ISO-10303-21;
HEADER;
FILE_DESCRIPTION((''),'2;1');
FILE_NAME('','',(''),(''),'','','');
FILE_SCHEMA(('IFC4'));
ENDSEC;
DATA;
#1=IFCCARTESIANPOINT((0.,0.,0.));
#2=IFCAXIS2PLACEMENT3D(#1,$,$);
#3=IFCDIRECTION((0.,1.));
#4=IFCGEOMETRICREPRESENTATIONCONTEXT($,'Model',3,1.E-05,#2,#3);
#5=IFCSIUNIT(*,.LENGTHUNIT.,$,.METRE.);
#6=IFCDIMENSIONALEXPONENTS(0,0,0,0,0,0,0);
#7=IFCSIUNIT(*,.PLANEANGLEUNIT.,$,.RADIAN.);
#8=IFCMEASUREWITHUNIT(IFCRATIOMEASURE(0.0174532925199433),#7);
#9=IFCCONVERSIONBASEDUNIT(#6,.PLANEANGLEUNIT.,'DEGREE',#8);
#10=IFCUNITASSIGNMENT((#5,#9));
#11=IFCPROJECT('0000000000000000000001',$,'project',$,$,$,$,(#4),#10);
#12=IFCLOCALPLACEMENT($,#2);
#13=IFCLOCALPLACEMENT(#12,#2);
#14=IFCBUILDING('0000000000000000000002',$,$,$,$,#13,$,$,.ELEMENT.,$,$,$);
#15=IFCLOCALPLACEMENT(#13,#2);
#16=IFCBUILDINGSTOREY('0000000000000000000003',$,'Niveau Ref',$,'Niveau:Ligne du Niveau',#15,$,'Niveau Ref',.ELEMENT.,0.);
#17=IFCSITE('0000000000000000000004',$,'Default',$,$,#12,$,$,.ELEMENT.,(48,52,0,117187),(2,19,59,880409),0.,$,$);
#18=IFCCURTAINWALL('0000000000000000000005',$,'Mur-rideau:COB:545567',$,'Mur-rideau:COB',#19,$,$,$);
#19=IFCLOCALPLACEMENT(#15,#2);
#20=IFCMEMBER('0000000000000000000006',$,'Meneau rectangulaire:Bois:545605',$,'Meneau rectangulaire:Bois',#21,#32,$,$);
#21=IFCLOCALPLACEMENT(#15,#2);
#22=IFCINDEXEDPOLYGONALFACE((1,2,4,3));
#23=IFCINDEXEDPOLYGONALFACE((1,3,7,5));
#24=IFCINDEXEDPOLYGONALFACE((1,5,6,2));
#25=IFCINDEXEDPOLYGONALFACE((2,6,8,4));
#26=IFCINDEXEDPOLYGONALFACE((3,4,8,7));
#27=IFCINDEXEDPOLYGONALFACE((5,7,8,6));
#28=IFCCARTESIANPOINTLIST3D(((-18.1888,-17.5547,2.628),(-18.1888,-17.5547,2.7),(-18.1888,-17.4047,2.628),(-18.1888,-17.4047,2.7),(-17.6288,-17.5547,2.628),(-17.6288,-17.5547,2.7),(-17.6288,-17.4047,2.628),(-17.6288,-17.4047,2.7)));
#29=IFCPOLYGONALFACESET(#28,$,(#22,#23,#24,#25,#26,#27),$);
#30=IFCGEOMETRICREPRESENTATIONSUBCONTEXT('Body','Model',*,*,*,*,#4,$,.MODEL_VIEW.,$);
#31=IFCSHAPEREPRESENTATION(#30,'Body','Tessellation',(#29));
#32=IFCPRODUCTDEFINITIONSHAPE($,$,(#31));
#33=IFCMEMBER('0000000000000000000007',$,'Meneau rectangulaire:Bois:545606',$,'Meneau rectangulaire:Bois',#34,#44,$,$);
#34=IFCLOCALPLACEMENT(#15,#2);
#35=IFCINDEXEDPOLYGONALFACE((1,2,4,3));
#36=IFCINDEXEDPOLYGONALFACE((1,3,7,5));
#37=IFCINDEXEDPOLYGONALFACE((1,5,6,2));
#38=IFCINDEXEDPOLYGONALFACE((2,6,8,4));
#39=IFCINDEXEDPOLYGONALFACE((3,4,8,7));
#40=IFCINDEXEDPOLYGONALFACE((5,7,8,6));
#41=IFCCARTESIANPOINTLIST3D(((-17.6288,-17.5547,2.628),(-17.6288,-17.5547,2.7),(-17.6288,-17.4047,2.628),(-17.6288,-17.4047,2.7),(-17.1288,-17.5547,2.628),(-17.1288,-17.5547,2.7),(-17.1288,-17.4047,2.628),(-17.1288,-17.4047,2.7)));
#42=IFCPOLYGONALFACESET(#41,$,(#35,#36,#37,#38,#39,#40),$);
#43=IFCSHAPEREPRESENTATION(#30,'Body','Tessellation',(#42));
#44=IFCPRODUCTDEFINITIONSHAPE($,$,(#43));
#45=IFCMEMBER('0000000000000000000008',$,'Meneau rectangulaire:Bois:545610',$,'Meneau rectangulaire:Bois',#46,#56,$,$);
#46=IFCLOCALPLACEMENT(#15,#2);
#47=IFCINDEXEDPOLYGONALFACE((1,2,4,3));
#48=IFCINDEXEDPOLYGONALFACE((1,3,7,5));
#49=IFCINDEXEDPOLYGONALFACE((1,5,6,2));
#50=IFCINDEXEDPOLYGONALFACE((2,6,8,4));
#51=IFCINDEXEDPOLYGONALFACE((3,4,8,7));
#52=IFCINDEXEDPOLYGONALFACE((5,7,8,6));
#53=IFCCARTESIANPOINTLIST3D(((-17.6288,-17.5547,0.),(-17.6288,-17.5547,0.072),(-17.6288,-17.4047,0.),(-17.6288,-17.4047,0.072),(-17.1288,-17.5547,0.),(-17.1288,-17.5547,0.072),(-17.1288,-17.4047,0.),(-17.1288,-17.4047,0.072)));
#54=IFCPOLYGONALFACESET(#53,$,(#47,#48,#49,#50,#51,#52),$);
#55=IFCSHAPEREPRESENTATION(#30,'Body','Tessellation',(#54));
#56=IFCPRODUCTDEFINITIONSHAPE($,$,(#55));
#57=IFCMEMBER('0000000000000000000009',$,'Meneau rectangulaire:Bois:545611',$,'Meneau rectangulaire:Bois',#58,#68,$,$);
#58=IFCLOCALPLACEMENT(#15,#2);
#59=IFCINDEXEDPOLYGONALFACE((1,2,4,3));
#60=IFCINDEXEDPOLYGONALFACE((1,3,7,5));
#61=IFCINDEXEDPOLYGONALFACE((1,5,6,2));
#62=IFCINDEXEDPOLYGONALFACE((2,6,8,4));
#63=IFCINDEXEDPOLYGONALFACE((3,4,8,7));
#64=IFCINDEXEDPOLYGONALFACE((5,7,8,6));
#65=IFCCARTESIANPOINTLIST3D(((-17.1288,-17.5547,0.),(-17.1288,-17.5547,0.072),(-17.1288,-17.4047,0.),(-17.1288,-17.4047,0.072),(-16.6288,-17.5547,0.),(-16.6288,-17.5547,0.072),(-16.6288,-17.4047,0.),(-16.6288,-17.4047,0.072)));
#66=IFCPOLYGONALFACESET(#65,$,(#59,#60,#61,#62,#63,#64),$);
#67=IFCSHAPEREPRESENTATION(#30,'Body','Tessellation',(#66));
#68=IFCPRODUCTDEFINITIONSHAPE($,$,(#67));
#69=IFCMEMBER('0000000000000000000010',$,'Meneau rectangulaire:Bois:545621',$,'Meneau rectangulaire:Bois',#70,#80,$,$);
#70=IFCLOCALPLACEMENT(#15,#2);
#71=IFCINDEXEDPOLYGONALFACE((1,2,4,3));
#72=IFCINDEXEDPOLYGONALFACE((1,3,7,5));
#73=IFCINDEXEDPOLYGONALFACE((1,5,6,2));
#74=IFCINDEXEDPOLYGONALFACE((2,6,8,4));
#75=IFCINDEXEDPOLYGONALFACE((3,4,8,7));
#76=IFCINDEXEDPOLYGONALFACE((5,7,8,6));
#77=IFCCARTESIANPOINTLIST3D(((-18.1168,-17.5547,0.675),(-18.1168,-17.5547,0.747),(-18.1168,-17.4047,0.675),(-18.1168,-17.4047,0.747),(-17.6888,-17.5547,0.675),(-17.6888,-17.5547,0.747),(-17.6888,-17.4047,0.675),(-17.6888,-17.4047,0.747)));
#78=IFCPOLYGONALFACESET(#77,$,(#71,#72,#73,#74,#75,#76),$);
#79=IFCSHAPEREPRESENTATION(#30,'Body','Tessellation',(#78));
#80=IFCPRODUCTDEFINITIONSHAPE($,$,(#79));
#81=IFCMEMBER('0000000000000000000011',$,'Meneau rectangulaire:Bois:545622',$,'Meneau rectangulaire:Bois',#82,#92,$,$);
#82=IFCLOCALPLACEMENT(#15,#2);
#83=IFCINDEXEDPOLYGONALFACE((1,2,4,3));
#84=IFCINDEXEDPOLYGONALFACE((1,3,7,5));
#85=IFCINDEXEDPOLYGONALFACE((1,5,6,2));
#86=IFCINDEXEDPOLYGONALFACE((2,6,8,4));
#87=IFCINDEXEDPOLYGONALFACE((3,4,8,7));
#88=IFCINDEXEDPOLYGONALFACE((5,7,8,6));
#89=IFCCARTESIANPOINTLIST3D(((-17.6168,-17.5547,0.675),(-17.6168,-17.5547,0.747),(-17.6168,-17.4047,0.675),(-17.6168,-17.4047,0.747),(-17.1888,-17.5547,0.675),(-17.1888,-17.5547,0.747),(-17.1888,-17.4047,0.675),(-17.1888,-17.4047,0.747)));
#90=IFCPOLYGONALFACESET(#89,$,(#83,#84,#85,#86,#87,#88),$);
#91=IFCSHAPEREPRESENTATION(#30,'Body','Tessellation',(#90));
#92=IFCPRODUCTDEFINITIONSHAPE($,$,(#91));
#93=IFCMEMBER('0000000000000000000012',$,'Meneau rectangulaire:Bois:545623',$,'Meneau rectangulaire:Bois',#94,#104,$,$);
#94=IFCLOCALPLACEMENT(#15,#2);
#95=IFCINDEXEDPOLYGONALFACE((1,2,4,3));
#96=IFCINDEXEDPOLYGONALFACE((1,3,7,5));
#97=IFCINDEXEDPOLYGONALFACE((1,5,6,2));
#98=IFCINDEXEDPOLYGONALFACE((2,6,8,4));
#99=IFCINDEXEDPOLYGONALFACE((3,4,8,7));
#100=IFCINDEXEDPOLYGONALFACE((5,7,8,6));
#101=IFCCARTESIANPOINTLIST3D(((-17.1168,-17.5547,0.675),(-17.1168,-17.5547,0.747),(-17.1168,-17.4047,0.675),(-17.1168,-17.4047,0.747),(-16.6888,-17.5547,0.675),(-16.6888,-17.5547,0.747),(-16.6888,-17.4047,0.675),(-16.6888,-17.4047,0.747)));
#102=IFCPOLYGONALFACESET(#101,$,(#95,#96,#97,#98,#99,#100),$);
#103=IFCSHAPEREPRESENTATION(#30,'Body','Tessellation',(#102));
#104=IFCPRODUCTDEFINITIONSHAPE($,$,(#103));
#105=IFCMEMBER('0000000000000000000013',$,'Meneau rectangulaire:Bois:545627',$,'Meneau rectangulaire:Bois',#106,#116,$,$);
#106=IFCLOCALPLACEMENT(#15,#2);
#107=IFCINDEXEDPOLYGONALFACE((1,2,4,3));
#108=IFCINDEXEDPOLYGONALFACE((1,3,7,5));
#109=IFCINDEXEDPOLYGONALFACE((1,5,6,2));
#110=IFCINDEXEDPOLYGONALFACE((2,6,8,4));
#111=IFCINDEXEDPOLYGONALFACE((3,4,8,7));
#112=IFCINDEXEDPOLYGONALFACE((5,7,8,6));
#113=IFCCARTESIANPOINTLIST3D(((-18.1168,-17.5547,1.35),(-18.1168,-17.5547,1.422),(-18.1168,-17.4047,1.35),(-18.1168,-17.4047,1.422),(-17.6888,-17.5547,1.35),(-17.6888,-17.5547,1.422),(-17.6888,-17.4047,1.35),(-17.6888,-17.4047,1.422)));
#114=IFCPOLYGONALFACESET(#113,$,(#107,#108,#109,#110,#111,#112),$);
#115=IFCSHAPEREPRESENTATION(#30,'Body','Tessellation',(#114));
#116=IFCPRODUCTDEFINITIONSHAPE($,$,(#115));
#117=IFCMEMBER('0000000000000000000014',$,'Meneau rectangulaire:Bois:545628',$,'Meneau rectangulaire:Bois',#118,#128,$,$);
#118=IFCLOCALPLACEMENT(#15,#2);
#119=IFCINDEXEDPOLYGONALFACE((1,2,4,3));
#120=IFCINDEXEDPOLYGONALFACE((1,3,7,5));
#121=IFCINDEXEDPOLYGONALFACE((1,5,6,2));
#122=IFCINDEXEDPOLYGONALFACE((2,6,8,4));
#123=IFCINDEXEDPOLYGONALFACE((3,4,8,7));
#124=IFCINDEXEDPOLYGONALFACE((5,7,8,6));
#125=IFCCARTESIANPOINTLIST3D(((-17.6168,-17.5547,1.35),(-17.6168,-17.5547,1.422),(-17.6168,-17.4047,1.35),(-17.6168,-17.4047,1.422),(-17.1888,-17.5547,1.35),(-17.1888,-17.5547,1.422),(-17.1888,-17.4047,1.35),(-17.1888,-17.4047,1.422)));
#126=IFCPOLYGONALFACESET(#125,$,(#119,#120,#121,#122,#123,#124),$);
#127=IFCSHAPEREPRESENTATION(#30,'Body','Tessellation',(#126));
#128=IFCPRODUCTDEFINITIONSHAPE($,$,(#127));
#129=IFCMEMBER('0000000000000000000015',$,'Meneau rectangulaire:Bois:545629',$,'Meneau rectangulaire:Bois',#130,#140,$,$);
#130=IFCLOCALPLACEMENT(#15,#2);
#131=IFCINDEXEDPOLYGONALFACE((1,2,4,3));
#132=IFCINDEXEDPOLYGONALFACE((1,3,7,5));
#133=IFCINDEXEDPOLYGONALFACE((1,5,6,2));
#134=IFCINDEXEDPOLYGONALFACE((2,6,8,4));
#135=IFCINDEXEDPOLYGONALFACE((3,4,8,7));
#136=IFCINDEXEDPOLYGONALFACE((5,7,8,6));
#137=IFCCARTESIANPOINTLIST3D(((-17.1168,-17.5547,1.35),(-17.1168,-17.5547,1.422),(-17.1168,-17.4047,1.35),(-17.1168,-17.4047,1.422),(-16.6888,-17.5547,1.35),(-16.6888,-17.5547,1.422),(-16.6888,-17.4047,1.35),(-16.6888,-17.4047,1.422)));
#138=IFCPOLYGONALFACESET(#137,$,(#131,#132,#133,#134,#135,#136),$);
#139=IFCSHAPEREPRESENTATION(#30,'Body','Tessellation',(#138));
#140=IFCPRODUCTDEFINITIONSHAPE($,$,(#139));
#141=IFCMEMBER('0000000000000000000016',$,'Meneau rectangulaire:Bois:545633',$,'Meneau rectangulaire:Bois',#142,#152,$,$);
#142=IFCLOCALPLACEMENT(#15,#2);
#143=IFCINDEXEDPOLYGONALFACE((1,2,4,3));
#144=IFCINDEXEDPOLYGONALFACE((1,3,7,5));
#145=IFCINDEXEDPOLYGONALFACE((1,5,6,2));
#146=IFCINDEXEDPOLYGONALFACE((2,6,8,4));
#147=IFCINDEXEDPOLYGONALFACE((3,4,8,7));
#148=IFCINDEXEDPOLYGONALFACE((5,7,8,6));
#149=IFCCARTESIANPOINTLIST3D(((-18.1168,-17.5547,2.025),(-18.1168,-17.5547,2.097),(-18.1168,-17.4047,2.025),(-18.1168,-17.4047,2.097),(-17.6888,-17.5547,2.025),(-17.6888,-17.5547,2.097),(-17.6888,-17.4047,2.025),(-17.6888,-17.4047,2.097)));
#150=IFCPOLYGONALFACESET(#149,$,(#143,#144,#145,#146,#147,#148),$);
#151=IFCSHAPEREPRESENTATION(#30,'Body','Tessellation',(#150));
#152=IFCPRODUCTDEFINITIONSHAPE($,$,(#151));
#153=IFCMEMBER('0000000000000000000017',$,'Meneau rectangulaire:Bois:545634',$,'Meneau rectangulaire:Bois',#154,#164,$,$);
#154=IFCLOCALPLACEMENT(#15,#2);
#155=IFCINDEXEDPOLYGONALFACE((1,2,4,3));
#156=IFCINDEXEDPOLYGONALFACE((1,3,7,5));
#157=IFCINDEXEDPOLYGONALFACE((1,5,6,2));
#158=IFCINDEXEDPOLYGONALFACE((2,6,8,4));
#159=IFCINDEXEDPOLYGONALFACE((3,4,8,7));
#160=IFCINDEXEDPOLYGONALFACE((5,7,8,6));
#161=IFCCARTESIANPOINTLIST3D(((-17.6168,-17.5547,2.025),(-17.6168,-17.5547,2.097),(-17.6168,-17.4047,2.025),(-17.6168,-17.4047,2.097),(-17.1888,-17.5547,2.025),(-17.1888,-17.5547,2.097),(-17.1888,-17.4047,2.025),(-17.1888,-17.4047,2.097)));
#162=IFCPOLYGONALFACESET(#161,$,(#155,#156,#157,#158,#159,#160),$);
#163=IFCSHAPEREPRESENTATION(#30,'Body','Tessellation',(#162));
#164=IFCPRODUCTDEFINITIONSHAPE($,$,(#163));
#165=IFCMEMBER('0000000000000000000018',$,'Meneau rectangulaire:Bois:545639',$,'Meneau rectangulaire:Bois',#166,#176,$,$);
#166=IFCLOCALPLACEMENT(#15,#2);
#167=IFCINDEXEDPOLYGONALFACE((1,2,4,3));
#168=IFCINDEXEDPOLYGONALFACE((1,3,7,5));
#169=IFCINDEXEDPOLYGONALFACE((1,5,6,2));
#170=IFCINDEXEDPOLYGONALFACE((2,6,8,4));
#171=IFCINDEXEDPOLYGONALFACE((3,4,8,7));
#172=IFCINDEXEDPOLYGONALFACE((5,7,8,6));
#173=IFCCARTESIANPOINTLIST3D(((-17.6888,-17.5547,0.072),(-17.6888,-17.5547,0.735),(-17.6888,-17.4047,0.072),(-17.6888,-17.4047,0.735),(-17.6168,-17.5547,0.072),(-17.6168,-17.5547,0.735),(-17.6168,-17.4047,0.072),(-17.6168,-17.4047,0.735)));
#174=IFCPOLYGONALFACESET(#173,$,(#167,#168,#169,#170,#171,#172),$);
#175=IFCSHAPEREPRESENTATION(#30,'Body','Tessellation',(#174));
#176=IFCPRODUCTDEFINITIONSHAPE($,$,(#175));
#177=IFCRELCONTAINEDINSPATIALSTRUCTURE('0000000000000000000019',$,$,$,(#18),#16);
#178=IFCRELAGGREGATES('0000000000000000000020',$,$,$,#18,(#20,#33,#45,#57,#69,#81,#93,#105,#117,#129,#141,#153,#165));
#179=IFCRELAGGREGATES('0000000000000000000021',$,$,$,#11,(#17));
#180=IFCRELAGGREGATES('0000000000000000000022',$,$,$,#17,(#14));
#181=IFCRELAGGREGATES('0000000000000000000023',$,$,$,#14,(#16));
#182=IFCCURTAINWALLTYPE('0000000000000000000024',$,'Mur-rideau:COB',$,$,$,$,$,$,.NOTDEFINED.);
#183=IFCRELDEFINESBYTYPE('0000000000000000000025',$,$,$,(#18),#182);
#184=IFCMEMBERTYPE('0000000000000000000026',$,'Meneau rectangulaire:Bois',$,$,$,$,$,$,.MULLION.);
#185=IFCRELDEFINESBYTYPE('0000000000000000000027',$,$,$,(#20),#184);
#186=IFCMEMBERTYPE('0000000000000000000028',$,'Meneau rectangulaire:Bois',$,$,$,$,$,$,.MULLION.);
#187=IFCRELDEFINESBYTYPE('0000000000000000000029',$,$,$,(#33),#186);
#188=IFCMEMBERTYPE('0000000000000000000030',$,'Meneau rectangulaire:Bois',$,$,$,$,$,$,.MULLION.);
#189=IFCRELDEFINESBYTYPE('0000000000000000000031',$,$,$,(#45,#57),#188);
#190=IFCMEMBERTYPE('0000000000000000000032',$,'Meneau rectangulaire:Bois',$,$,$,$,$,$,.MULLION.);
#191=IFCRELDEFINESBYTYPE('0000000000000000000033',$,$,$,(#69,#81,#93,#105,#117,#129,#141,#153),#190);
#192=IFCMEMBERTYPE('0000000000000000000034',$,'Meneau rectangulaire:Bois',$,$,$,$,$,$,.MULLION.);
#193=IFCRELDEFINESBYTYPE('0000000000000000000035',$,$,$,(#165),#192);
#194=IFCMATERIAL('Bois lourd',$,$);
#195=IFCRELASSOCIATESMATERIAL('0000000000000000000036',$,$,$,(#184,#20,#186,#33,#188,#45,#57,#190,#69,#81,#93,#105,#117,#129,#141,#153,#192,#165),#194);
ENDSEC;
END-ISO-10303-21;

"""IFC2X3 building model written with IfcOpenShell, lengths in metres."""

from ifc_helpers import new_model, entity, si_unit, converted_unit, direction, frame, origin, origin_2d_with_axis, place, context, subcontext, project, spatial, rectangle, extrude, source, transform, mapped, material, type_object, type_shapes, element, aggregate, save


model = new_model("IFC2X3")

# Units and contexts
model_context = context("Model", 3, precision=1e-05, world=origin(), true_north=direction((0.0, 1.0)))
body_context = subcontext(model_context, "Body", "Model", "MODEL_VIEW")
ifc_project = project(units=[si_unit("LENGTHUNIT", "METRE"), converted_unit("PLANEANGLEUNIT", "DEGREE", entity("IfcRatioMeasure", 0.0174532925199433), si_unit("PLANEANGLEUNIT", "RADIAN"), dimensions=[0, 0, 0, 0, 0, 0, 0])], contexts=[model_context])

# Site, building, storey
site_placement = place(None, origin())
site = spatial("IfcSite", under=ifc_project, at=site_placement, Name="Default", CompositionType="ELEMENT", RefLatitude=(48, 52, 0, 117187), RefLongitude=(2, 19, 59, 880409), RefElevation=0.0)
building_placement = place(site_placement, origin())
building = spatial("IfcBuilding", under=site, at=building_placement, CompositionType="ELEMENT")
storey_placement = place(building_placement, origin())
storey = spatial("IfcBuildingStorey", under=building, at=storey_placement, Name="Niveau Ref", ObjectType="Niveau:Ligne du Niveau", LongName="Niveau Ref", CompositionType="ELEMENT", Elevation=0.0)

# Curtain wall, members
curtain_wall_type_1 = type_object("IfcCurtainWallType", Name="Mur-rideau:COB", PredefinedType="NOTDEFINED")
curtain_wall_1_placement = place(storey_placement, origin())
curtain_wall_1 = element("IfcCurtainWall", 1, at=curtain_wall_1_placement, inside=storey, type_object=curtain_wall_type_1, Name="Mur-rideau:COB:545567", ObjectType="Mur-rideau:COB")
ifc_material_1 = material(Name="Bois lourd")
member_type_1 = type_object("IfcMemberType", Name="Meneau rectangulaire:Bois", PredefinedType="MULLION", material=ifc_material_1)
shared_shape_1 = source(origin(), body_context, "Body", "SweptSolid", [
    extrude(rectangle(XDim=0.15, YDim=0.072, at=origin_2d_with_axis()), frame((-0.036, 0.0, -0.56), z_axis=(0.0, 0.0, 1.0), x_axis=(0.0, -1.0, 0.0)), (0.0, 0.0, 1.0), 0.56),
])
type_shapes(member_type_1, [shared_shape_1])
member_1_placement = place(storey_placement, frame((-17.6288, -17.4797, 2.7), z_axis=(1.0, 0.0, 0.0), x_axis=(0.0, 0.0, 1.0)))
member_1 = element("IfcMember", 2, at=member_1_placement, type_object=member_type_1, material=ifc_material_1, Name="Meneau rectangulaire:Bois:545605", ObjectType="Meneau rectangulaire:Bois", context=body_context, shape_type="MappedRepresentation", body=[
    mapped(shared_shape_1, transform((0.0, 0.0, 0.0), scale=1.0)),
])
member_type_2 = type_object("IfcMemberType", Name="Meneau rectangulaire:Bois", PredefinedType="MULLION", material=ifc_material_1)
shared_shape_2 = source(origin(), body_context, "Body", "SweptSolid", [
    extrude(rectangle(XDim=0.15, YDim=0.072, at=origin_2d_with_axis()), frame((-0.036, 0.0, -0.5), z_axis=(0.0, 0.0, 1.0), x_axis=(0.0, -1.0, 0.0)), (0.0, 0.0, 1.0), 0.5),
])
type_shapes(member_type_2, [shared_shape_2])
member_2_placement = place(storey_placement, frame((-17.1288, -17.4797, 2.7), z_axis=(1.0, 0.0, 0.0), x_axis=(0.0, 0.0, 1.0)))
member_2 = element("IfcMember", 3, at=member_2_placement, type_object=member_type_2, material=ifc_material_1, Name="Meneau rectangulaire:Bois:545606", ObjectType="Meneau rectangulaire:Bois", context=body_context, shape_type="MappedRepresentation", body=[
    mapped(shared_shape_2, transform((0.0, 0.0, 0.0), scale=1.0)),
])
member_type_3 = type_object("IfcMemberType", Name="Meneau rectangulaire:Bois", PredefinedType="MULLION", material=ifc_material_1)
shared_shape_3 = source(origin(), body_context, "Body", "SweptSolid", [
    extrude(rectangle(XDim=0.15, YDim=0.072, at=origin_2d_with_axis()), frame((-0.036, 0.0, -0.5), z_axis=(0.0, 0.0, 1.0), x_axis=(0.0, -1.0, 0.0)), (0.0, 0.0, 1.0), 0.5),
])
type_shapes(member_type_3, [shared_shape_3])
member_3_placement = place(storey_placement, frame((-17.6288, -17.4797, 0.0), z_axis=(-1.0, 0.0, 0.0), x_axis=(0.0, 0.0, -1.0)))
member_3 = element("IfcMember", 4, at=member_3_placement, type_object=member_type_3, material=ifc_material_1, Name="Meneau rectangulaire:Bois:545610", ObjectType="Meneau rectangulaire:Bois", context=body_context, shape_type="MappedRepresentation", body=[
    mapped(shared_shape_3, transform((0.0, 0.0, 0.0), scale=1.0)),
])
member_4_placement = place(storey_placement, frame((-17.1288, -17.4797, 0.0), z_axis=(-1.0, 0.0, 0.0), x_axis=(0.0, 0.0, -1.0)))
member_4 = element("IfcMember", 5, at=member_4_placement, type_object=member_type_3, material=ifc_material_1, Name="Meneau rectangulaire:Bois:545611", ObjectType="Meneau rectangulaire:Bois", context=body_context, shape_type="MappedRepresentation", body=[
    mapped(shared_shape_3, transform((0.0, 0.0, 0.0), scale=1.0)),
])
member_type_4 = type_object("IfcMemberType", Name="Meneau rectangulaire:Bois", PredefinedType="MULLION", material=ifc_material_1)
shared_shape_4 = source(origin(), body_context, "Body", "SweptSolid", [
    extrude(rectangle(XDim=0.15, YDim=0.072, at=origin_2d_with_axis()), frame((-0.024, 0.0, -0.428), z_axis=(0.0, 0.0, 1.0), x_axis=(0.0, -1.0, 0.0)), (0.0, 0.0, 1.0), 0.428),
])
type_shapes(member_type_4, [shared_shape_4])
member_5_placement = place(storey_placement, frame((-17.6888, -17.4797, 0.735), z_axis=(1.0, 0.0, 0.0), x_axis=(0.0, 0.0, 1.0)))
member_5 = element("IfcMember", 6, at=member_5_placement, type_object=member_type_4, material=ifc_material_1, Name="Meneau rectangulaire:Bois:545621", ObjectType="Meneau rectangulaire:Bois", context=body_context, shape_type="MappedRepresentation", body=[
    mapped(shared_shape_4, transform((0.0, 0.0, 0.0), scale=1.0)),
])
member_6_placement = place(storey_placement, frame((-17.1888, -17.4797, 0.735), z_axis=(1.0, 0.0, 0.0), x_axis=(0.0, 0.0, 1.0)))
member_6 = element("IfcMember", 7, at=member_6_placement, type_object=member_type_4, material=ifc_material_1, Name="Meneau rectangulaire:Bois:545622", ObjectType="Meneau rectangulaire:Bois", context=body_context, shape_type="MappedRepresentation", body=[
    mapped(shared_shape_4, transform((0.0, 0.0, 0.0), scale=1.0)),
])
member_7_placement = place(storey_placement, frame((-16.6888, -17.4797, 0.735), z_axis=(1.0, 0.0, 0.0), x_axis=(0.0, 0.0, 1.0)))
member_7 = element("IfcMember", 8, at=member_7_placement, type_object=member_type_4, material=ifc_material_1, Name="Meneau rectangulaire:Bois:545623", ObjectType="Meneau rectangulaire:Bois", context=body_context, shape_type="MappedRepresentation", body=[
    mapped(shared_shape_4, transform((0.0, 0.0, 0.0), scale=1.0)),
])
member_8_placement = place(storey_placement, frame((-17.6888, -17.4797, 1.41), z_axis=(1.0, 0.0, 0.0), x_axis=(0.0, 0.0, 1.0)))
member_8 = element("IfcMember", 9, at=member_8_placement, type_object=member_type_4, material=ifc_material_1, Name="Meneau rectangulaire:Bois:545627", ObjectType="Meneau rectangulaire:Bois", context=body_context, shape_type="MappedRepresentation", body=[
    mapped(shared_shape_4, transform((0.0, 0.0, 0.0), scale=1.0)),
])
member_9_placement = place(storey_placement, frame((-17.1888, -17.4797, 1.41), z_axis=(1.0, 0.0, 0.0), x_axis=(0.0, 0.0, 1.0)))
member_9 = element("IfcMember", 10, at=member_9_placement, type_object=member_type_4, material=ifc_material_1, Name="Meneau rectangulaire:Bois:545628", ObjectType="Meneau rectangulaire:Bois", context=body_context, shape_type="MappedRepresentation", body=[
    mapped(shared_shape_4, transform((0.0, 0.0, 0.0), scale=1.0)),
])
member_10_placement = place(storey_placement, frame((-16.6888, -17.4797, 1.41), z_axis=(1.0, 0.0, 0.0), x_axis=(0.0, 0.0, 1.0)))
member_10 = element("IfcMember", 11, at=member_10_placement, type_object=member_type_4, material=ifc_material_1, Name="Meneau rectangulaire:Bois:545629", ObjectType="Meneau rectangulaire:Bois", context=body_context, shape_type="MappedRepresentation", body=[
    mapped(shared_shape_4, transform((0.0, 0.0, 0.0), scale=1.0)),
])
member_11_placement = place(storey_placement, frame((-17.6888, -17.4797, 2.085), z_axis=(1.0, 0.0, 0.0), x_axis=(0.0, 0.0, 1.0)))
member_11 = element("IfcMember", 12, at=member_11_placement, type_object=member_type_4, material=ifc_material_1, Name="Meneau rectangulaire:Bois:545633", ObjectType="Meneau rectangulaire:Bois", context=body_context, shape_type="MappedRepresentation", body=[
    mapped(shared_shape_4, transform((0.0, 0.0, 0.0), scale=1.0)),
])
member_12_placement = place(storey_placement, frame((-17.1888, -17.4797, 2.085), z_axis=(1.0, 0.0, 0.0), x_axis=(0.0, 0.0, 1.0)))
member_12 = element("IfcMember", 13, at=member_12_placement, type_object=member_type_4, material=ifc_material_1, Name="Meneau rectangulaire:Bois:545634", ObjectType="Meneau rectangulaire:Bois", context=body_context, shape_type="MappedRepresentation", body=[
    mapped(shared_shape_4, transform((0.0, 0.0, 0.0), scale=1.0)),
])
member_type_5 = type_object("IfcMemberType", Name="Meneau rectangulaire:Bois", PredefinedType="MULLION", material=ifc_material_1)
shared_shape_5 = source(origin(), body_context, "Body", "SweptSolid", [
    extrude(rectangle(XDim=0.15, YDim=0.072, at=origin_2d_with_axis()), frame((-0.024, 0.0, -0.663), z_axis=(0.0, 0.0, 1.0), x_axis=(0.0, -1.0, 0.0)), (0.0, 0.0, 1.0), 0.663),
])
type_shapes(member_type_5, [shared_shape_5])
member_13_placement = place(storey_placement, frame((-17.6288, -17.4797, 0.072), z_axis=(0.0, 0.0, -1.0), x_axis=(1.0, 0.0, 0.0)))
member_13 = element("IfcMember", 14, at=member_13_placement, type_object=member_type_5, material=ifc_material_1, Name="Meneau rectangulaire:Bois:545639", ObjectType="Meneau rectangulaire:Bois", context=body_context, shape_type="MappedRepresentation", body=[
    mapped(shared_shape_5, transform((0.0, 0.0, 0.0), scale=1.0)),
])
aggregate(curtain_wall_1, [member_1, member_2, member_3, member_4, member_5, member_6, member_7, member_8, member_9, member_10, member_11, member_12, member_13])

save(model, "model.ifc")
